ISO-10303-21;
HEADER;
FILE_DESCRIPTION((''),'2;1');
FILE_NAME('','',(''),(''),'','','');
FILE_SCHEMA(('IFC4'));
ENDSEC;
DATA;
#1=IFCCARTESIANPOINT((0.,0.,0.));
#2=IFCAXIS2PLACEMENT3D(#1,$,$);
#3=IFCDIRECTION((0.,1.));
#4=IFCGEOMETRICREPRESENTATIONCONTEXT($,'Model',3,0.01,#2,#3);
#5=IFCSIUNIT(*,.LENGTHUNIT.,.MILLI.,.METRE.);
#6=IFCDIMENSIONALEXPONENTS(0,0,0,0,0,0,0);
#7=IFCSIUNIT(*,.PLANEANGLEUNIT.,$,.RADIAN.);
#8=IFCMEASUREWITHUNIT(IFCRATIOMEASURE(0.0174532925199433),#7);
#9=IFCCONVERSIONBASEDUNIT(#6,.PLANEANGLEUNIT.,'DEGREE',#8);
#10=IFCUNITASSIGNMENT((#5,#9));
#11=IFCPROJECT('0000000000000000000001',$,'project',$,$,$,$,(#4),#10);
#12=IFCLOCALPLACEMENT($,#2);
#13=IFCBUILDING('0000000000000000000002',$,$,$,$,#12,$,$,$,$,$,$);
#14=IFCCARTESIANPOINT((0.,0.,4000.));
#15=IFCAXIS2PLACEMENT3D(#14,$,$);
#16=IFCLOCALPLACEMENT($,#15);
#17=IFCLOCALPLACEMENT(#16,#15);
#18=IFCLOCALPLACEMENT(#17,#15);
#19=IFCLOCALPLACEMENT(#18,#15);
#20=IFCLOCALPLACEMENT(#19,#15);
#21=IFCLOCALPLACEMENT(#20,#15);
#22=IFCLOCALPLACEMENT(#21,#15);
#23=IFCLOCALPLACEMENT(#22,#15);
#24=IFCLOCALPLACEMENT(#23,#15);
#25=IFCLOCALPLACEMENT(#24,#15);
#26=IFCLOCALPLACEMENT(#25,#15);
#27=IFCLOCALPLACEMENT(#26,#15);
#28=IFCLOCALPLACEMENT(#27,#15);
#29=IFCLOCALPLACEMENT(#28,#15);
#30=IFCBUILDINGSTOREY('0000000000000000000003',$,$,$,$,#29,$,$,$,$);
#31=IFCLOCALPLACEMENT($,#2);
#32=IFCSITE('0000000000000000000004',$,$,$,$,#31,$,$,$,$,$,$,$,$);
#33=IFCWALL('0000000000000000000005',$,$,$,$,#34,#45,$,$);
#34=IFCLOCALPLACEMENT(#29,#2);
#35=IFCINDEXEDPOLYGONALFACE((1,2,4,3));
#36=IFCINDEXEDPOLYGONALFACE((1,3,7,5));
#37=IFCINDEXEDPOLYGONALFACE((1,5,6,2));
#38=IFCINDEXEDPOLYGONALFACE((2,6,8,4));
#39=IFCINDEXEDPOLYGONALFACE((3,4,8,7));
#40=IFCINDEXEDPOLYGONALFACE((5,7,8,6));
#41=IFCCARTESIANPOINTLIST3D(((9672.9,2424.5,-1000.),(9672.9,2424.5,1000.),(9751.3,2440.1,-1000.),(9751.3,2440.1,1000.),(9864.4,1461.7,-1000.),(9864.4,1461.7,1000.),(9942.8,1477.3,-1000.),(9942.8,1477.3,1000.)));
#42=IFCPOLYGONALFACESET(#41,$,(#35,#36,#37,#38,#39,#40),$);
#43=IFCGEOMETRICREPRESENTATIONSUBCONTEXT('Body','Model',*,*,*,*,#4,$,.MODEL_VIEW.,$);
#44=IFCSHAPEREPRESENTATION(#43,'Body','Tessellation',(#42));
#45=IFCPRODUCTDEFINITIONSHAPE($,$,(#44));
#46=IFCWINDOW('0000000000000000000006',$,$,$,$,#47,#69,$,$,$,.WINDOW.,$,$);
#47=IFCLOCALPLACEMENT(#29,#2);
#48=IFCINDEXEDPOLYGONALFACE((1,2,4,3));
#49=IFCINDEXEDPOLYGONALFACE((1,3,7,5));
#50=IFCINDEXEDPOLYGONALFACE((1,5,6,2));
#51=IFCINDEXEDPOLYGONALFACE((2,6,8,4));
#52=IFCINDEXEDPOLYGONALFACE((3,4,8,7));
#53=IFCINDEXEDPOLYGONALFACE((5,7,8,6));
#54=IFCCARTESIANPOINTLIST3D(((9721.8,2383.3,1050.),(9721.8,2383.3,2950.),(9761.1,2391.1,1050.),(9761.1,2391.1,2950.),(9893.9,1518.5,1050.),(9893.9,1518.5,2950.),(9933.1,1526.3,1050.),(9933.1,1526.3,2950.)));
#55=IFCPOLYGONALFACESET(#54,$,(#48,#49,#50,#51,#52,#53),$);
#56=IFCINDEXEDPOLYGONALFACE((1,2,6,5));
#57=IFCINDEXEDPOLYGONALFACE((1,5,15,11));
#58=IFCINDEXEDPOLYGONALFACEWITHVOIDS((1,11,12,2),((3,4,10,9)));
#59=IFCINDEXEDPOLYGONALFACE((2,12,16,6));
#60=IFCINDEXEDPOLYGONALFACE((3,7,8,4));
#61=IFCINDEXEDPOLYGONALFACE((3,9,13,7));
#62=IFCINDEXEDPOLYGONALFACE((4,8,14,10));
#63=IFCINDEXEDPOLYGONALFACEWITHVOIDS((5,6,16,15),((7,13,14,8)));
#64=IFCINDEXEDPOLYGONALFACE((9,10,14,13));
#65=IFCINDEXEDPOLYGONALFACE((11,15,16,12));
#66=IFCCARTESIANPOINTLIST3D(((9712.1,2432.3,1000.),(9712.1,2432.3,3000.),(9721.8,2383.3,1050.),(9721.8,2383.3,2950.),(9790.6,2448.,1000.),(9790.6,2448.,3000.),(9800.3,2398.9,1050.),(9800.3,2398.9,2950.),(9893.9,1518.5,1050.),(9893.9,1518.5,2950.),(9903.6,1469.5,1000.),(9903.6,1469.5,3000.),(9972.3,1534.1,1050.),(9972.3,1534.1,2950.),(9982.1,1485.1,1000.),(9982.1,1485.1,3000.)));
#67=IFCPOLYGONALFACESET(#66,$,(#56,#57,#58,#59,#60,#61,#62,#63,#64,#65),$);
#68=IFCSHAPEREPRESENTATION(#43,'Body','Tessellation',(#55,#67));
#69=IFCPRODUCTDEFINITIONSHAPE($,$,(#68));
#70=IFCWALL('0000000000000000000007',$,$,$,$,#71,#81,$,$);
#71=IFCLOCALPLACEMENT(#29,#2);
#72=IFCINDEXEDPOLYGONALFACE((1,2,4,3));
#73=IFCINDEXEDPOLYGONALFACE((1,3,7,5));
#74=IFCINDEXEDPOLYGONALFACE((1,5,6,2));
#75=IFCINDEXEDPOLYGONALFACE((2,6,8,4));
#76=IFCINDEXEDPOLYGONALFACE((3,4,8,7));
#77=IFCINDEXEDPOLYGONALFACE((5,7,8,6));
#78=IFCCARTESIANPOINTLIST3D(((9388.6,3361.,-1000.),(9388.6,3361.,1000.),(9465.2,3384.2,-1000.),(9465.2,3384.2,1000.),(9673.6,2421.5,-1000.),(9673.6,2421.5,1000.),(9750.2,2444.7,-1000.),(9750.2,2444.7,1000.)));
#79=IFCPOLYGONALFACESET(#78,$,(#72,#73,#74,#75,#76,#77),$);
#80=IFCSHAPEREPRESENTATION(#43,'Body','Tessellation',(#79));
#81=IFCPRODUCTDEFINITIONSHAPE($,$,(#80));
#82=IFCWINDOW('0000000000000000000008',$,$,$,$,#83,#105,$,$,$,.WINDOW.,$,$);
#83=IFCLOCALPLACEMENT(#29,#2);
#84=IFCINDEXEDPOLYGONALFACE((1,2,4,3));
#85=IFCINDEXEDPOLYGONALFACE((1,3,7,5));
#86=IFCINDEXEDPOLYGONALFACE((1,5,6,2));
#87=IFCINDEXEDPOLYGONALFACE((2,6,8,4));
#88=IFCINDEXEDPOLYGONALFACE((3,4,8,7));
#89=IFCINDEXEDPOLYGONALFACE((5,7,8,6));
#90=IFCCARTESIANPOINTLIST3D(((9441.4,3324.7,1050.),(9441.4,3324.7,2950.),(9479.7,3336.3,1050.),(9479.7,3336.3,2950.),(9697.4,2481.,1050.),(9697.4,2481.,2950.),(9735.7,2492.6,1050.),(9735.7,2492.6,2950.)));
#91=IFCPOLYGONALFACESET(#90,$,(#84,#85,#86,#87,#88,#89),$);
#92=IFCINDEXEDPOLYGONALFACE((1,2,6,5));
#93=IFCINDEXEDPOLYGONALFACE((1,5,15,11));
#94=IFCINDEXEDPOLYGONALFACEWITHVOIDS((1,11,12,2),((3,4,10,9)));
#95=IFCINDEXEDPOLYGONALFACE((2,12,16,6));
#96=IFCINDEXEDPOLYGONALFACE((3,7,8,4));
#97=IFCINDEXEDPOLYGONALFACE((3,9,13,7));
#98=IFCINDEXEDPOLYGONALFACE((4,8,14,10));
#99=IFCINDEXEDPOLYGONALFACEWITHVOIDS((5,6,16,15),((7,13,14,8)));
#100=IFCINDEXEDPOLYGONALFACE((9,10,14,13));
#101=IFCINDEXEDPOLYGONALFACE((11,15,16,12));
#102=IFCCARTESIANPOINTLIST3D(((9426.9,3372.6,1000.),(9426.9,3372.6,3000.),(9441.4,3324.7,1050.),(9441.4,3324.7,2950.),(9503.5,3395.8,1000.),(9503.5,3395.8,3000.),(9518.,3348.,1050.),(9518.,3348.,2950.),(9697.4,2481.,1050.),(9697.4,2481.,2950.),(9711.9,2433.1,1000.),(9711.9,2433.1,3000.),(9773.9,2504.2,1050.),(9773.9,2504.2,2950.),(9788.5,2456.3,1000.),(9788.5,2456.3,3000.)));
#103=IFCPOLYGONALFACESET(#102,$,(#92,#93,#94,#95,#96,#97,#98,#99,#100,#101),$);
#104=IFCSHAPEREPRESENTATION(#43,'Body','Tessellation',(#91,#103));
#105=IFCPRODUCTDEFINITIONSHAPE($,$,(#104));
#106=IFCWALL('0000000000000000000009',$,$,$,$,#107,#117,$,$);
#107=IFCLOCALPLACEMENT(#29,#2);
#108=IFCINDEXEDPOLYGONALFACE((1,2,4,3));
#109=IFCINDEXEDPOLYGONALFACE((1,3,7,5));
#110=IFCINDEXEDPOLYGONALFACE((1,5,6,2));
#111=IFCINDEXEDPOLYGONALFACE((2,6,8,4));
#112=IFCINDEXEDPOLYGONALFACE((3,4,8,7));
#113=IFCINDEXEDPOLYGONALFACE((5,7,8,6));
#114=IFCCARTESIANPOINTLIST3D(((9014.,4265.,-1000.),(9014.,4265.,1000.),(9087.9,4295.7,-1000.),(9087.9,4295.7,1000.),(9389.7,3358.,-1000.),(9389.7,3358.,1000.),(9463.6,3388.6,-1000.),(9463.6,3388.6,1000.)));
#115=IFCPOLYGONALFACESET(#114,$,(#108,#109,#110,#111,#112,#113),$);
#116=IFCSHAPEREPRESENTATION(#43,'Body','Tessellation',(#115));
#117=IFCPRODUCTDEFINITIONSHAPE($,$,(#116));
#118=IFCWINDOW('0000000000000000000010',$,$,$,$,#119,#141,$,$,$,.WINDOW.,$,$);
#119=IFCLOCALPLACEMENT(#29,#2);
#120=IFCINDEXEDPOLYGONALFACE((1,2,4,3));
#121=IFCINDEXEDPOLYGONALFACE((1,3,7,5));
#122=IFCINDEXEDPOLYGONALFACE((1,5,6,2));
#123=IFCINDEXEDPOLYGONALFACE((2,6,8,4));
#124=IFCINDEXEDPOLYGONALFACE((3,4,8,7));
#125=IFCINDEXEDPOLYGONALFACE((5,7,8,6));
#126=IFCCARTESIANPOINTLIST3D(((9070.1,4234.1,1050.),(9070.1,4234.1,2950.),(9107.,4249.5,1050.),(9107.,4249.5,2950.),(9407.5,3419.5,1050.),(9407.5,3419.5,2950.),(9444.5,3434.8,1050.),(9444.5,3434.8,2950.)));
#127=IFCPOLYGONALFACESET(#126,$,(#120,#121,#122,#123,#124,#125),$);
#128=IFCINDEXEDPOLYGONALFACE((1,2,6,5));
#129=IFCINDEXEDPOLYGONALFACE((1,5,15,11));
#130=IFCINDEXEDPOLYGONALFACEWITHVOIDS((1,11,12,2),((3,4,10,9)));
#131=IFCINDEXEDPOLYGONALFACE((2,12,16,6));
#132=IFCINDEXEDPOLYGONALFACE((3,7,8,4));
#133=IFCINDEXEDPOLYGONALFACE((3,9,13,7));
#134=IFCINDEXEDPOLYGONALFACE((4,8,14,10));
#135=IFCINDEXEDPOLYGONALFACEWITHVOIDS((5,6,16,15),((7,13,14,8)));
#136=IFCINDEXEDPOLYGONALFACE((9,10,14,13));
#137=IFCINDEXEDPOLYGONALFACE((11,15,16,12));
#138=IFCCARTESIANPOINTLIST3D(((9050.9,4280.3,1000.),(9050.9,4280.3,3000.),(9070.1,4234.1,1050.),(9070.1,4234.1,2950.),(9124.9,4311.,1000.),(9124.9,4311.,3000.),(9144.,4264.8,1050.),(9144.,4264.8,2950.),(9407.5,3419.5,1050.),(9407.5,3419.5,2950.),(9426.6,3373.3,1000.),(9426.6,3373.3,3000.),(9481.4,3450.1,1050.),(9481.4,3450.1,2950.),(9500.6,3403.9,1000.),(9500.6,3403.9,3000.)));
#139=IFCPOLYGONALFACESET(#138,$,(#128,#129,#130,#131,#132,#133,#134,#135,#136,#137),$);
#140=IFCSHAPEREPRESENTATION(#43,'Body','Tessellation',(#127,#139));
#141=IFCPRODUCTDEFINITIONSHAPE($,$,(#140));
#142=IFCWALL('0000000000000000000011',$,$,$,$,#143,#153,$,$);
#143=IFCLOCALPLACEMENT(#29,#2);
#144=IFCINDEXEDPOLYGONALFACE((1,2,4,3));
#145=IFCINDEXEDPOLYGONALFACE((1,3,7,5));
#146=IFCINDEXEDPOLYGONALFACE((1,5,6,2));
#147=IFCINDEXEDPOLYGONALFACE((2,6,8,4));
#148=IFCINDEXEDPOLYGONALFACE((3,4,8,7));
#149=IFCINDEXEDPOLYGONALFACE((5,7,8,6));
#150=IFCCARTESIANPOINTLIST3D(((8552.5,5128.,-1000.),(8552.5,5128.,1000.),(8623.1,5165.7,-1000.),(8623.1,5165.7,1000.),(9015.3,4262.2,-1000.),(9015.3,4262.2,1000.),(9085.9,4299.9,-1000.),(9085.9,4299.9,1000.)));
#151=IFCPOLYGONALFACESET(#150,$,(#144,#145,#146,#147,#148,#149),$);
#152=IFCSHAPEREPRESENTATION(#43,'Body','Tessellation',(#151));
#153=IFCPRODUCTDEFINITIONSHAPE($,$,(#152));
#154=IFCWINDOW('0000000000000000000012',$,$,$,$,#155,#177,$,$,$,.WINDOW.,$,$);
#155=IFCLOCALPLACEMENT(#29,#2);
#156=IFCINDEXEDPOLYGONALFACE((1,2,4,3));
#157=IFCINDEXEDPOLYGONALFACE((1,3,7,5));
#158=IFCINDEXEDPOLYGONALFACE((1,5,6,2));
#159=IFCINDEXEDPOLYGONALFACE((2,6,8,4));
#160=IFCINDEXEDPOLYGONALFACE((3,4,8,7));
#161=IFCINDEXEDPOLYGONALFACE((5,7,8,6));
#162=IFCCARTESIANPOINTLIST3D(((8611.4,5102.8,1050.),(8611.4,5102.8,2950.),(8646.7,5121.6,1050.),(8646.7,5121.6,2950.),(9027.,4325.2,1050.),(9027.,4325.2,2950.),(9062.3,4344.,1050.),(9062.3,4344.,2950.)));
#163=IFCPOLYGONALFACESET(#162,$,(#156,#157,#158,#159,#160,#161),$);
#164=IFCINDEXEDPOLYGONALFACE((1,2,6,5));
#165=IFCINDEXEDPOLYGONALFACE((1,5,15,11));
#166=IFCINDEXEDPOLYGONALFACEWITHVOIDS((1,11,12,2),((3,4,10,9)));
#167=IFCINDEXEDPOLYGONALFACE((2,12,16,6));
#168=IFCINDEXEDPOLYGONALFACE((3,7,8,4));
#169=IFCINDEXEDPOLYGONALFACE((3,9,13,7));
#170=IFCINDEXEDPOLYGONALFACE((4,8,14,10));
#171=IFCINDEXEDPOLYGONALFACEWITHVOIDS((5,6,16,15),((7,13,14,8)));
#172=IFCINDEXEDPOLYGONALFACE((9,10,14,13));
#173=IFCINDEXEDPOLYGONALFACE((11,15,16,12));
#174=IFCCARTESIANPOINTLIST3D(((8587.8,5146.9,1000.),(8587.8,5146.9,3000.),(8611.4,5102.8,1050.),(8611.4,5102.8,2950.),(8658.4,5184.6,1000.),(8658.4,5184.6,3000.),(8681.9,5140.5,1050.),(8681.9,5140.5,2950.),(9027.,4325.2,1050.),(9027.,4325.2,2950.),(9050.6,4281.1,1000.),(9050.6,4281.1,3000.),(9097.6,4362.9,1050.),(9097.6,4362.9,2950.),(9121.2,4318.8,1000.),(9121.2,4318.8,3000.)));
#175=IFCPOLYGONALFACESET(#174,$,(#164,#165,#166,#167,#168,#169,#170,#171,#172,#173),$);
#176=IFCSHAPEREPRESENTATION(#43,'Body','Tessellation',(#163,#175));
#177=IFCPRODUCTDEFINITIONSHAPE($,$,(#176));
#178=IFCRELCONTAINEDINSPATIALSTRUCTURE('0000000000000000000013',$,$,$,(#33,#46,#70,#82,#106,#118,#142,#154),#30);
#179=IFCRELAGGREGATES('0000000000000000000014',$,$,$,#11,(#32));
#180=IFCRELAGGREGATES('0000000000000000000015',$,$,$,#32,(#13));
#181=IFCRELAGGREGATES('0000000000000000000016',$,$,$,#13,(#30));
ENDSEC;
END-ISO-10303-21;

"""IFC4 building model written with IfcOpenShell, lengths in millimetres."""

from ifc_helpers import new_model, entity, si_unit, converted_unit, direction, frame, origin, origin_2d, place, context, subcontext, project, spatial, rectangle, extrude, element, save


model = new_model("IFC4")

# Units and contexts
model_context = context("Model", 3, precision=0.01, world=origin(), true_north=direction((0.0, 1.0)))
body_context = subcontext(model_context, "Body", "Model", "MODEL_VIEW")
ifc_project = project(units=[si_unit("LENGTHUNIT", "METRE", prefix="MILLI"), converted_unit("PLANEANGLEUNIT", "DEGREE", entity("IfcRatioMeasure", 0.0174532925199433), si_unit("PLANEANGLEUNIT", "RADIAN"), dimensions=[0, 0, 0, 0, 0, 0, 0])], contexts=[model_context])

# Site, building, storey
site_placement = place(None, origin())
site = spatial("IfcSite", under=ifc_project, at=site_placement)
building_placement = place(None, origin())
building = spatial("IfcBuilding", under=site, at=building_placement)
placement_1 = place(None, frame((0.0, 0.0, 4000.0)))
placement_2 = place(placement_1, frame((0.0, 0.0, 4000.0)))
placement_3 = place(placement_2, frame((0.0, 0.0, 4000.0)))
placement_4 = place(placement_3, frame((0.0, 0.0, 4000.0)))
placement_5 = place(placement_4, frame((0.0, 0.0, 4000.0)))
placement_6 = place(placement_5, frame((0.0, 0.0, 4000.0)))
placement_7 = place(placement_6, frame((0.0, 0.0, 4000.0)))
placement_8 = place(placement_7, frame((0.0, 0.0, 4000.0)))
placement_9 = place(placement_8, frame((0.0, 0.0, 4000.0)))
placement_10 = place(placement_9, frame((0.0, 0.0, 4000.0)))
placement_11 = place(placement_10, frame((0.0, 0.0, 4000.0)))
placement_12 = place(placement_11, frame((0.0, 0.0, 4000.0)))
placement_13 = place(placement_12, frame((0.0, 0.0, 4000.0)))
storey_placement = place(placement_13, frame((0.0, 0.0, 4000.0)))
storey = spatial("IfcBuildingStorey", under=building, at=storey_placement)

# Shared definitions
cartesian_point_1 = entity("IfcCartesianPoint", [-440.9, -950.0])
shared_polyline = entity("IfcPolyline", [cartesian_point_1, entity("IfcCartesianPoint", [-440.9, 950.0]), entity("IfcCartesianPoint", [-440.9, 950.0]), entity("IfcCartesianPoint", [440.9, 950.0]), entity("IfcCartesianPoint", [440.9, 950.0]), entity("IfcCartesianPoint", [440.9, -950.0]), entity("IfcCartesianPoint", [440.9, -950.0]), entity("IfcCartesianPoint", [-440.9, -950.0]), cartesian_point_1])

# Wall
wall_1_placement = place(storey_placement, frame((9807.9, 1950.9, -1000.0), z_axis=(0.0, 0.0, 1.0), x_axis=(-1950.903274, 9807.852793, 0.0)))
element("IfcWall", 1, at=wall_1_placement, inside=storey, context=body_context, shape_type="SweptSolid", body=[
    extrude(rectangle(XDim=981.7, YDim=80.0, at=origin_2d()), origin(), (0.0, 0.0, 1.0), 2000.0),
])

# Window
window_1_placement = place(storey_placement, frame((9807.9, 1950.9, 2000.0), z_axis=(0.0, 0.0, 1.0), x_axis=(-1950.903274, 9807.852793, 0.0)))
cartesian_point_2 = entity("IfcCartesianPoint", [-490.9, -1000.0])
element("IfcWindow", 2, at=window_1_placement, inside=storey, PredefinedType="WINDOW", context=body_context, shape_type="SweptSolid", body=[
    entity("IfcExtrudedAreaSolid", entity("IfcArbitraryClosedProfileDef", "AREA", None, shared_polyline), entity("IfcAxis2Placement3D", entity("IfcCartesianPoint", [0.0, 0.0, 0.0]), entity("IfcDirection", [0.0, -1.0, 0.0]), entity("IfcDirection", [1.0, 0.0, 0.0])), entity("IfcDirection", [0.0, 0.0, 1.0]), 40.0),
    entity("IfcExtrudedAreaSolid", entity("IfcArbitraryProfileDefWithVoids", "AREA", None, entity("IfcPolyline", [cartesian_point_2, entity("IfcCartesianPoint", [-490.9, 1000.0]), entity("IfcCartesianPoint", [-490.9, 1000.0]), entity("IfcCartesianPoint", [490.9, 1000.0]), entity("IfcCartesianPoint", [490.9, 1000.0]), entity("IfcCartesianPoint", [490.9, -1000.0]), entity("IfcCartesianPoint", [490.9, -1000.0]), entity("IfcCartesianPoint", [-490.9, -1000.0]), cartesian_point_2]), [shared_polyline]), entity("IfcAxis2Placement3D", entity("IfcCartesianPoint", [0.0, 0.0, 0.0]), entity("IfcDirection", [0.0, -1.0, 0.0]), entity("IfcDirection", [1.0, 0.0, 0.0])), entity("IfcDirection", [0.0, 0.0, 1.0]), 80.0),
])

# Wall
wall_2_placement = place(storey_placement, frame((9569.4, 2902.8, -1000.0), z_axis=(0.0, 0.0, 1.0), x_axis=(-2902.84678, 9569.403355, 0.0)))
element("IfcWall", 3, at=wall_2_placement, inside=storey, context=body_context, shape_type="SweptSolid", body=[
    extrude(rectangle(XDim=981.7, YDim=80.0, at=origin_2d()), origin(), (0.0, 0.0, 1.0), 2000.0),
])

# Window
window_2_placement = place(storey_placement, frame((9569.4, 2902.8, 2000.0), z_axis=(0.0, 0.0, 1.0), x_axis=(-2902.84678, 9569.403355, 0.0)))
cartesian_point_3 = entity("IfcCartesianPoint", [-490.9, -1000.0])
element("IfcWindow", 4, at=window_2_placement, inside=storey, PredefinedType="WINDOW", context=body_context, shape_type="SweptSolid", body=[
    entity("IfcExtrudedAreaSolid", entity("IfcArbitraryClosedProfileDef", "AREA", None, shared_polyline), entity("IfcAxis2Placement3D", entity("IfcCartesianPoint", [0.0, 0.0, 0.0]), entity("IfcDirection", [0.0, -1.0, 0.0]), entity("IfcDirection", [1.0, 0.0, 0.0])), entity("IfcDirection", [0.0, 0.0, 1.0]), 40.0),
    entity("IfcExtrudedAreaSolid", entity("IfcArbitraryProfileDefWithVoids", "AREA", None, entity("IfcPolyline", [cartesian_point_3, entity("IfcCartesianPoint", [-490.9, 1000.0]), entity("IfcCartesianPoint", [-490.9, 1000.0]), entity("IfcCartesianPoint", [490.9, 1000.0]), entity("IfcCartesianPoint", [490.9, 1000.0]), entity("IfcCartesianPoint", [490.9, -1000.0]), entity("IfcCartesianPoint", [490.9, -1000.0]), entity("IfcCartesianPoint", [-490.9, -1000.0]), cartesian_point_3]), [shared_polyline]), entity("IfcAxis2Placement3D", entity("IfcCartesianPoint", [0.0, 0.0, 0.0]), entity("IfcDirection", [0.0, -1.0, 0.0]), entity("IfcDirection", [1.0, 0.0, 0.0])), entity("IfcDirection", [0.0, 0.0, 1.0]), 80.0),
])

# Wall
wall_3_placement = place(storey_placement, frame((9238.8, 3826.8, -1000.0), z_axis=(0.0, 0.0, 1.0), x_axis=(-3826.834425, 9238.795283, 0.0)))
element("IfcWall", 5, at=wall_3_placement, inside=storey, context=body_context, shape_type="SweptSolid", body=[
    extrude(rectangle(XDim=981.7, YDim=80.0, at=origin_2d()), origin(), (0.0, 0.0, 1.0), 2000.0),
])

# Window
window_3_placement = place(storey_placement, frame((9238.8, 3826.8, 2000.0), z_axis=(0.0, 0.0, 1.0), x_axis=(-3826.834425, 9238.795283, 0.0)))
cartesian_point_4 = entity("IfcCartesianPoint", [-490.9, -1000.0])
element("IfcWindow", 6, at=window_3_placement, inside=storey, PredefinedType="WINDOW", context=body_context, shape_type="SweptSolid", body=[
    entity("IfcExtrudedAreaSolid", entity("IfcArbitraryClosedProfileDef", "AREA", None, shared_polyline), entity("IfcAxis2Placement3D", entity("IfcCartesianPoint", [0.0, 0.0, 0.0]), entity("IfcDirection", [0.0, -1.0, 0.0]), entity("IfcDirection", [1.0, 0.0, 0.0])), entity("IfcDirection", [0.0, 0.0, 1.0]), 40.0),
    entity("IfcExtrudedAreaSolid", entity("IfcArbitraryProfileDefWithVoids", "AREA", None, entity("IfcPolyline", [cartesian_point_4, entity("IfcCartesianPoint", [-490.9, 1000.0]), entity("IfcCartesianPoint", [-490.9, 1000.0]), entity("IfcCartesianPoint", [490.9, 1000.0]), entity("IfcCartesianPoint", [490.9, 1000.0]), entity("IfcCartesianPoint", [490.9, -1000.0]), entity("IfcCartesianPoint", [490.9, -1000.0]), entity("IfcCartesianPoint", [-490.9, -1000.0]), cartesian_point_4]), [shared_polyline]), entity("IfcAxis2Placement3D", entity("IfcCartesianPoint", [0.0, 0.0, 0.0]), entity("IfcDirection", [0.0, -1.0, 0.0]), entity("IfcDirection", [1.0, 0.0, 0.0])), entity("IfcDirection", [0.0, 0.0, 1.0]), 80.0),
])

# Wall
wall_4_placement = place(storey_placement, frame((8819.2, 4714.0, -1000.0), z_axis=(0.0, 0.0, 1.0), x_axis=(-4713.967292, 8819.212684, 0.0)))
element("IfcWall", 7, at=wall_4_placement, inside=storey, context=body_context, shape_type="SweptSolid", body=[
    extrude(rectangle(XDim=981.7, YDim=80.0, at=origin_2d()), origin(), (0.0, 0.0, 1.0), 2000.0),
])

# Window
window_4_placement = place(storey_placement, frame((8819.2, 4714.0, 2000.0), z_axis=(0.0, 0.0, 1.0), x_axis=(-4713.967292, 8819.212684, 0.0)))
cartesian_point_5 = entity("IfcCartesianPoint", [-490.9, -1000.0])
element("IfcWindow", 8, at=window_4_placement, inside=storey, PredefinedType="WINDOW", context=body_context, shape_type="SweptSolid", body=[
    entity("IfcExtrudedAreaSolid", entity("IfcArbitraryClosedProfileDef", "AREA", None, shared_polyline), entity("IfcAxis2Placement3D", entity("IfcCartesianPoint", [0.0, 0.0, 0.0]), entity("IfcDirection", [0.0, -1.0, 0.0]), entity("IfcDirection", [1.0, 0.0, 0.0])), entity("IfcDirection", [0.0, 0.0, 1.0]), 40.0),
    entity("IfcExtrudedAreaSolid", entity("IfcArbitraryProfileDefWithVoids", "AREA", None, entity("IfcPolyline", [cartesian_point_5, entity("IfcCartesianPoint", [-490.9, 1000.0]), entity("IfcCartesianPoint", [-490.9, 1000.0]), entity("IfcCartesianPoint", [490.9, 1000.0]), entity("IfcCartesianPoint", [490.9, 1000.0]), entity("IfcCartesianPoint", [490.9, -1000.0]), entity("IfcCartesianPoint", [490.9, -1000.0]), entity("IfcCartesianPoint", [-490.9, -1000.0]), cartesian_point_5]), [shared_polyline]), entity("IfcAxis2Placement3D", entity("IfcCartesianPoint", [0.0, 0.0, 0.0]), entity("IfcDirection", [0.0, -1.0, 0.0]), entity("IfcDirection", [1.0, 0.0, 0.0])), entity("IfcDirection", [0.0, 0.0, 1.0]), 80.0),
])

save(model, "model.ifc")
